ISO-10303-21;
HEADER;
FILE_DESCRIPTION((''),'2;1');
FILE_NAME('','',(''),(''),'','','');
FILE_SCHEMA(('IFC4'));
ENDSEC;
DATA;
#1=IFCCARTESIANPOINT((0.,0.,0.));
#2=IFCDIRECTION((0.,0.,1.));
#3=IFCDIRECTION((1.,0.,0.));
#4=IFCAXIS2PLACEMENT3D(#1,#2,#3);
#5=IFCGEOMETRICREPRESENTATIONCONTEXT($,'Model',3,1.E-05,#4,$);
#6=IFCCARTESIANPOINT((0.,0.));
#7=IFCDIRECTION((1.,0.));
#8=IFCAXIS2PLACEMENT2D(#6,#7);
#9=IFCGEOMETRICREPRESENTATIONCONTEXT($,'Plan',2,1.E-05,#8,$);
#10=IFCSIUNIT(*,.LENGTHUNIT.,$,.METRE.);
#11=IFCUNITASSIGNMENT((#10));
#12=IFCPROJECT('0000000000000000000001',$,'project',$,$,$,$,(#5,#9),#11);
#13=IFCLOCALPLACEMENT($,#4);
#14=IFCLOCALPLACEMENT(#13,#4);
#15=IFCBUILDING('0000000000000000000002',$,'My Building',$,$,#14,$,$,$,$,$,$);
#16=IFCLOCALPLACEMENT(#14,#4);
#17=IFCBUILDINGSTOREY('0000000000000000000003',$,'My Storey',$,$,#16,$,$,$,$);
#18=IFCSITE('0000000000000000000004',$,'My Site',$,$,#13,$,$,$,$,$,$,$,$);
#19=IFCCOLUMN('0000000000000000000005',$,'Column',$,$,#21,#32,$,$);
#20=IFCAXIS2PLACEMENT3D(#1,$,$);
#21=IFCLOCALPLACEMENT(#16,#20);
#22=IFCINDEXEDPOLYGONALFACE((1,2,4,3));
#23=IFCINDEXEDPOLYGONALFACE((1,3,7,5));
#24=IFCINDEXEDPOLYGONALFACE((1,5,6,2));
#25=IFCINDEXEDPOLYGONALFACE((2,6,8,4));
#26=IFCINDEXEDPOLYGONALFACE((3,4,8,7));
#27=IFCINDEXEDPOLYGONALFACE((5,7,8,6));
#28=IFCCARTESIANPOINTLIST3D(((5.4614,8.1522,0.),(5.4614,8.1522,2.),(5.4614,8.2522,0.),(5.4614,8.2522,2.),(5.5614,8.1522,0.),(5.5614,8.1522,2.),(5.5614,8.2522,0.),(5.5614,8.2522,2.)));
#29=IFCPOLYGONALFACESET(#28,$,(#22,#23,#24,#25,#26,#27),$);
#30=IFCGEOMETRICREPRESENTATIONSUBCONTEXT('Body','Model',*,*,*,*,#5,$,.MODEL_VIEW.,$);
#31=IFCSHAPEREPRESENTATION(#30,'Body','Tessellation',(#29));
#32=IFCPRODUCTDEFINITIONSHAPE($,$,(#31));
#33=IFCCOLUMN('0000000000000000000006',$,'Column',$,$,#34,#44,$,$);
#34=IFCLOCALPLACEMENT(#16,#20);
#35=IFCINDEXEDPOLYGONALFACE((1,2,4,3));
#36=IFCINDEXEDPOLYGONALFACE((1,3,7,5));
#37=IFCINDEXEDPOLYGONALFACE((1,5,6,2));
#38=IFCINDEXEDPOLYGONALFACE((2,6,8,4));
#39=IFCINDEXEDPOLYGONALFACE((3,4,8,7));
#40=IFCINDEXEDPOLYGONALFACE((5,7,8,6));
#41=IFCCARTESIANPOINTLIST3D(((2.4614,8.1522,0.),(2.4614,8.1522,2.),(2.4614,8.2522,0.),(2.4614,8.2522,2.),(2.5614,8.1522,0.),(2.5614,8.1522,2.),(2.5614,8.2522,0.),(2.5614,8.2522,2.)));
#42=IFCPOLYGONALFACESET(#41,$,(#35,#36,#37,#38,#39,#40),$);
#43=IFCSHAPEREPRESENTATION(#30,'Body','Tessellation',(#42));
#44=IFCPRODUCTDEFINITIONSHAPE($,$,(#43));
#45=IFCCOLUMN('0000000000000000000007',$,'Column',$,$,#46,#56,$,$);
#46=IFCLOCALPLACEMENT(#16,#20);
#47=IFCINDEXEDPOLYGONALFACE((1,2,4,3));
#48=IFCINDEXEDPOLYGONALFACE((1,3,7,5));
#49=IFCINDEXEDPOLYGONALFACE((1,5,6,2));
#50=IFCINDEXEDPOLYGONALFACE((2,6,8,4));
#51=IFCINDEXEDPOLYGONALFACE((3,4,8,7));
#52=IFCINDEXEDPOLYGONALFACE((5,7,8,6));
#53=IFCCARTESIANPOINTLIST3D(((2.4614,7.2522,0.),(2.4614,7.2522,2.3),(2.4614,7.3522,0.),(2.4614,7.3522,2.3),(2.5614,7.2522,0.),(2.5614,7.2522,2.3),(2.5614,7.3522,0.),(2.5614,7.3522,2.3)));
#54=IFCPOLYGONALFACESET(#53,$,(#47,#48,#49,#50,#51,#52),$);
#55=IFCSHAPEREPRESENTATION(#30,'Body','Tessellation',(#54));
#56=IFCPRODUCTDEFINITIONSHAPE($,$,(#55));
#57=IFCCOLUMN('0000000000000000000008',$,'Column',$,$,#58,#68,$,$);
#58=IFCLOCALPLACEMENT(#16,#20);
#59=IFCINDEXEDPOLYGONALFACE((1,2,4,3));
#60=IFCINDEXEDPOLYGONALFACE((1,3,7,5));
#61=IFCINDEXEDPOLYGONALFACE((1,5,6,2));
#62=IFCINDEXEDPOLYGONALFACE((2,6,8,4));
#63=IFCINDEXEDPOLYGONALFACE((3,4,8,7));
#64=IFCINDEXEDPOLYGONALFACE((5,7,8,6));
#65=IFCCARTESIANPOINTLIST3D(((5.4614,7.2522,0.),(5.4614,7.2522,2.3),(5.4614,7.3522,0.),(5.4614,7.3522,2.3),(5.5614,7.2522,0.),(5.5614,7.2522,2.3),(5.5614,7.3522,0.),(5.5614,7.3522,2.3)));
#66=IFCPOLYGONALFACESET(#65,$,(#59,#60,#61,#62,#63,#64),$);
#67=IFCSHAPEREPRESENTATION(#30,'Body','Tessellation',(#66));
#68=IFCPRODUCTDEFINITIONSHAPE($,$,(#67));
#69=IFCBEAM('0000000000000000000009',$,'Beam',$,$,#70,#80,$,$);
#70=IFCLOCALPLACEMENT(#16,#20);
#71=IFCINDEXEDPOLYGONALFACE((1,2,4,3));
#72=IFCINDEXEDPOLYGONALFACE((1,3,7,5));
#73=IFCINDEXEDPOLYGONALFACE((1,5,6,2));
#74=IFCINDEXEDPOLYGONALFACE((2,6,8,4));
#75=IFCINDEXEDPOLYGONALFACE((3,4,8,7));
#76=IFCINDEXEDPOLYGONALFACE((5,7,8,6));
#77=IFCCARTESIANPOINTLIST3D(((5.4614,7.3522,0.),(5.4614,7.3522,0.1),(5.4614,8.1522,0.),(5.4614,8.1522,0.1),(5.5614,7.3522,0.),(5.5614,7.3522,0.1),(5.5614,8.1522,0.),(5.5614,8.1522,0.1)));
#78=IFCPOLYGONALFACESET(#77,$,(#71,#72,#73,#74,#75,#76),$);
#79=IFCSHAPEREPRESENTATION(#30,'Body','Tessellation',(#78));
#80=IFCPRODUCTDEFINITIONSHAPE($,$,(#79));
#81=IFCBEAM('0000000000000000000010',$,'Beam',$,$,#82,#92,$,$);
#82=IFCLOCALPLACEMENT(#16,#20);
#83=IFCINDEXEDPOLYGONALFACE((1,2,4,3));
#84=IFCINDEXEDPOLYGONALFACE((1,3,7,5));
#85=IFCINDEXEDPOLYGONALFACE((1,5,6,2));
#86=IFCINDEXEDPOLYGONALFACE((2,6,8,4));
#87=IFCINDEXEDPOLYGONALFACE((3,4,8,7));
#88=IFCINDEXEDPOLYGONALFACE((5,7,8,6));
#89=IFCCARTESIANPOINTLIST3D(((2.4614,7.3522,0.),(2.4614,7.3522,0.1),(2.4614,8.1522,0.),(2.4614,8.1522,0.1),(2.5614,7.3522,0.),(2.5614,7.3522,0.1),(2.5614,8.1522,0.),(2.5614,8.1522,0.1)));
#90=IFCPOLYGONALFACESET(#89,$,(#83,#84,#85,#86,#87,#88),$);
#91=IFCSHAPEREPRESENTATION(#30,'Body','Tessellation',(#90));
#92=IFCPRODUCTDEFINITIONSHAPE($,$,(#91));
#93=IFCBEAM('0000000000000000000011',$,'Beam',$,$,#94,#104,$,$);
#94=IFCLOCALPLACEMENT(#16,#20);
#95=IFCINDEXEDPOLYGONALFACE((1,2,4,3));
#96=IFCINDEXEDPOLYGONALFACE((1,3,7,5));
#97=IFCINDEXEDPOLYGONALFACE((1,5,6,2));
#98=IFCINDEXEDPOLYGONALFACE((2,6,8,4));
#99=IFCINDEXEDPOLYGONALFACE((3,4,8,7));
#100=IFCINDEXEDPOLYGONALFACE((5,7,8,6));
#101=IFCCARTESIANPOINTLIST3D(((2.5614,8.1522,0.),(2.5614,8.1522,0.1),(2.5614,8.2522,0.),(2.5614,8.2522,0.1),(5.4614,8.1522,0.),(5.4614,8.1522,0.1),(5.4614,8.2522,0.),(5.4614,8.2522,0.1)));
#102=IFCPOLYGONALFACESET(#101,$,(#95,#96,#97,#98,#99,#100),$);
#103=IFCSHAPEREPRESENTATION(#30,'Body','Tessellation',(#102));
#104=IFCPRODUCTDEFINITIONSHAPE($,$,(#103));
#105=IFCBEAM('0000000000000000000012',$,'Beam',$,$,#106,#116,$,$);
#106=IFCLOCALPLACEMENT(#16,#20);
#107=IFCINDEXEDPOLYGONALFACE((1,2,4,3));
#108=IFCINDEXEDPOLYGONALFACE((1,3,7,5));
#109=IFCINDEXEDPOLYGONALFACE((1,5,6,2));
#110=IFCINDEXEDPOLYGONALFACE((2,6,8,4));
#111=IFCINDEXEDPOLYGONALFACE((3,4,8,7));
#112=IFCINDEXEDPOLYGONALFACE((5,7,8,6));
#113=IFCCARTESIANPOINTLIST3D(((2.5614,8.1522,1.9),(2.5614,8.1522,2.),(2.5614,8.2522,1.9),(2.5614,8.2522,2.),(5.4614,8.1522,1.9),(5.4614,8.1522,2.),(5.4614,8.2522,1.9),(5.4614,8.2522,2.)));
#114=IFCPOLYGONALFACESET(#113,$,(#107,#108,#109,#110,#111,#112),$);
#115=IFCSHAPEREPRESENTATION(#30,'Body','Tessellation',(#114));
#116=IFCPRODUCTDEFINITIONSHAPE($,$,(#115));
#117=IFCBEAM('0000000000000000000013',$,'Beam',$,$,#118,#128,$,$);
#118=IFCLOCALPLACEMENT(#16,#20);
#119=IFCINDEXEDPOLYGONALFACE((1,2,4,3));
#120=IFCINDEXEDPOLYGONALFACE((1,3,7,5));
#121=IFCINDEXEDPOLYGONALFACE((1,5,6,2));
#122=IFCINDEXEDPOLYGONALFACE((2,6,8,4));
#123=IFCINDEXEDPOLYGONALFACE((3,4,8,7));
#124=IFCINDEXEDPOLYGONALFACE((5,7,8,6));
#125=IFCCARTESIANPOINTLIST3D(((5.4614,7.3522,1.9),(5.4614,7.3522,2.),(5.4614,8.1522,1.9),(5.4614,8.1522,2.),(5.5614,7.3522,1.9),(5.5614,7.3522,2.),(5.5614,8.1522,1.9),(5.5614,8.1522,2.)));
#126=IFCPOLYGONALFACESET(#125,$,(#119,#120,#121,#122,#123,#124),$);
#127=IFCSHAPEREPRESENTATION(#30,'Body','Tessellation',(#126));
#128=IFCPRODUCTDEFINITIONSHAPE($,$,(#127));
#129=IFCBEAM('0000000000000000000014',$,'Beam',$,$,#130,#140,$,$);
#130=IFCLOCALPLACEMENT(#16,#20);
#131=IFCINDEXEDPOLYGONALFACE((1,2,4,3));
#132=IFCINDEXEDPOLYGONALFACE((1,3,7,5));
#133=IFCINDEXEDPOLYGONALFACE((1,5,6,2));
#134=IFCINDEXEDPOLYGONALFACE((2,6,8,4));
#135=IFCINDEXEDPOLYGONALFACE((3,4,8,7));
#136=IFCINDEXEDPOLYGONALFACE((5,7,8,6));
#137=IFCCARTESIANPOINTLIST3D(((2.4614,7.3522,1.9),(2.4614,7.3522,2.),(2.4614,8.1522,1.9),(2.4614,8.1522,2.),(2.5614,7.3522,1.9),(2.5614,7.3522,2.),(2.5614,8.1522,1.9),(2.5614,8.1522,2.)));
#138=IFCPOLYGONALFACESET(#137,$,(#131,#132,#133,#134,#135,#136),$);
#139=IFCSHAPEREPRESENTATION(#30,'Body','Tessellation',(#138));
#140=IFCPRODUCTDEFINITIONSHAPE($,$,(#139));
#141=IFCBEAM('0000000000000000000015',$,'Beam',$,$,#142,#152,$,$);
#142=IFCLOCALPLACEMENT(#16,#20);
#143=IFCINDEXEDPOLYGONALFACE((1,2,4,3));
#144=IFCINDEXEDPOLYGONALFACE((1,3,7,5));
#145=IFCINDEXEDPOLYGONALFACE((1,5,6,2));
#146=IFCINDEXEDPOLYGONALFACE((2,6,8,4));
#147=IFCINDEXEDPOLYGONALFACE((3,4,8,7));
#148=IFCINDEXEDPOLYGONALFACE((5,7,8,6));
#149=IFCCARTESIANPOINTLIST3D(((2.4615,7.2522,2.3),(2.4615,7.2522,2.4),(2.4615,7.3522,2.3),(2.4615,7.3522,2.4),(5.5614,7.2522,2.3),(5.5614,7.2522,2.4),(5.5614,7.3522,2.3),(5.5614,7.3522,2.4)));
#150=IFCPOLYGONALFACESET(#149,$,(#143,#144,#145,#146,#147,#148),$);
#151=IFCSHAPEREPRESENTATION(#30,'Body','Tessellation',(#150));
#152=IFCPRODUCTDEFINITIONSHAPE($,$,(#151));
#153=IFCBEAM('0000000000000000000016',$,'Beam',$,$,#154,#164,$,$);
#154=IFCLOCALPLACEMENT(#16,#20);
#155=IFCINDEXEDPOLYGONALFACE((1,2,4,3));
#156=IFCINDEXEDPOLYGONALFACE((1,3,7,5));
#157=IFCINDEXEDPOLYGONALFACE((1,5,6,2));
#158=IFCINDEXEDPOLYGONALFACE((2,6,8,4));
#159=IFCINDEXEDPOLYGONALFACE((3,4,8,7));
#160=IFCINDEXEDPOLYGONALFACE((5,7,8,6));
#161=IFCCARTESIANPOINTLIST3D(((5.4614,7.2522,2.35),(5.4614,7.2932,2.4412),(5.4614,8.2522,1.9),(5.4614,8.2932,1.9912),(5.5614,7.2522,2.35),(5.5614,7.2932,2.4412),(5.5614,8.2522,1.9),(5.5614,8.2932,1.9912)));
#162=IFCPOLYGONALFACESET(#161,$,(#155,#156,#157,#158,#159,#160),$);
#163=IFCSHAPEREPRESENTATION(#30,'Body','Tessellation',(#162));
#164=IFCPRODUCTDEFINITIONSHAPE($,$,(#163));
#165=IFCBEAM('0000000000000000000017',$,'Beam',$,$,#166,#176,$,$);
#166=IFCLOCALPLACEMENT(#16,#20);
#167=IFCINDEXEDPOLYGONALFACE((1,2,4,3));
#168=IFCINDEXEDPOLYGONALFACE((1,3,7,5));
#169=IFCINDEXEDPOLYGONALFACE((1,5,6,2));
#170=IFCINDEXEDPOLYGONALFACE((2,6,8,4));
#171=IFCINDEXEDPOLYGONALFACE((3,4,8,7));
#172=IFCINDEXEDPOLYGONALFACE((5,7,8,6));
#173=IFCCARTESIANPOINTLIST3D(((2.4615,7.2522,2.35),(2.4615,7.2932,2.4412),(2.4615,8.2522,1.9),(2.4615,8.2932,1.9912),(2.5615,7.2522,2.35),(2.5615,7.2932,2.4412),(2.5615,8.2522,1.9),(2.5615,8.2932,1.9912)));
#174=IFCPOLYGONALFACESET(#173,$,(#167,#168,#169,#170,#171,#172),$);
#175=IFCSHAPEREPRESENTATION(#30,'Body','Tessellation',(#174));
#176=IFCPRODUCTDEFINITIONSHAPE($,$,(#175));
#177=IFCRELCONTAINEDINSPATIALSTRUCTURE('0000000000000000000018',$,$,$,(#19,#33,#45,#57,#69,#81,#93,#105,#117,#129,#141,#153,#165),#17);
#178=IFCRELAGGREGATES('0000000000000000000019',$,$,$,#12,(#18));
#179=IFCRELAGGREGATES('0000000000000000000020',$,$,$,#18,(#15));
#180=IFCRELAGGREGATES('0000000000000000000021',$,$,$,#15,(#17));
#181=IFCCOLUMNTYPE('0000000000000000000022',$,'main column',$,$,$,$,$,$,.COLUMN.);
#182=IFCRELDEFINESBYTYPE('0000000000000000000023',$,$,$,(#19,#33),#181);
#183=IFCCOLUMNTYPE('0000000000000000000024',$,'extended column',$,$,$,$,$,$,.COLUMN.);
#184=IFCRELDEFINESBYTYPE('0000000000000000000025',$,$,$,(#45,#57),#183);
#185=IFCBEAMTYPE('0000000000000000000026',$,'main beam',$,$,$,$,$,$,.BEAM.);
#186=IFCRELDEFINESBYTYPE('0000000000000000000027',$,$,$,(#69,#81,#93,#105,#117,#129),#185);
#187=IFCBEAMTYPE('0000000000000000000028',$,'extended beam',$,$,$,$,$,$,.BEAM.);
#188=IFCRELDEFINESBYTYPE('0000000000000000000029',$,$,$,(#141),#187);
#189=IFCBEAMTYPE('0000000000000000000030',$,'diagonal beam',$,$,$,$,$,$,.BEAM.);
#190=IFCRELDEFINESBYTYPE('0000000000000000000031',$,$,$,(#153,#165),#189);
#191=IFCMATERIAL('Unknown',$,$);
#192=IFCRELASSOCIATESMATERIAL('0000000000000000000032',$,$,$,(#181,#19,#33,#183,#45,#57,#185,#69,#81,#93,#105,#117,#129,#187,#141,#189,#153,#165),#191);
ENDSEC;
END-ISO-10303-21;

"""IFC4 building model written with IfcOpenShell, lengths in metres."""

from ifc_helpers import new_model, si_unit, frame, origin_with_axes, origin_2d_with_axis, place, context, subcontext, project, spatial, rectangle, extrude, material, material_profile, profile_set, profile_usage, type_object, element, save


model = new_model("IFC4")

# Units and contexts
model_context = context("Model", 3, precision=1e-05, world=origin_with_axes())
plan_context = context("Plan", 2, precision=1e-05, world=origin_2d_with_axis())
body_context = subcontext(model_context, "Body", "Model", "MODEL_VIEW")
ifc_project = project(units=[si_unit("LENGTHUNIT", "METRE")], contexts=[model_context, plan_context])

# Site, building, storey
site_placement = place(None, origin_with_axes())
site = spatial("IfcSite", under=ifc_project, at=site_placement, Name="My Site")
building_placement = place(site_placement, origin_with_axes())
building = spatial("IfcBuilding", under=site, at=building_placement, Name="My Building")
storey_placement = place(building_placement, origin_with_axes())
storey = spatial("IfcBuildingStorey", under=building, at=storey_placement, Name="My Storey")

# Columns
ifc_material_1 = material(Name="Unknown")
ifc_material_profile_1 = material_profile(ifc_material_1, rectangle(XDim=0.1, YDim=0.1))
ifc_profile_set_1 = profile_set([ifc_material_profile_1])
ifc_profile_usage_1 = profile_usage(ifc_profile_set_1, cardinal=5)
column_type_1 = type_object("IfcColumnType", Name="main column", PredefinedType="COLUMN", material=ifc_profile_set_1)
column_1_placement = place(storey_placement, frame((5.5114, 8.2022, 0.0), z_axis=(0.0, 0.0, 1.0), x_axis=(0.0, 1.0, 0.0)))
element("IfcColumn", 1, at=column_1_placement, inside=storey, type_object=column_type_1, material=ifc_profile_usage_1, Name="Column", context=body_context, shape_type="SweptSolid", body=[
    extrude(rectangle(XDim=0.1, YDim=0.1), origin_with_axes(), (0.0, 0.0, 1.0), 2.0),
])
ifc_profile_usage_2 = profile_usage(ifc_profile_set_1, cardinal=5)
column_2_placement = place(storey_placement, frame((2.5114, 8.2022, 0.0), z_axis=(0.0, 0.0, 1.0), x_axis=(0.0, 1.0, 0.0)))
element("IfcColumn", 2, at=column_2_placement, inside=storey, type_object=column_type_1, material=ifc_profile_usage_2, Name="Column", context=body_context, shape_type="SweptSolid", body=[
    extrude(rectangle(XDim=0.1, YDim=0.1), origin_with_axes(), (0.0, 0.0, 1.0), 2.0),
])
ifc_material_profile_2 = material_profile(ifc_material_1, rectangle(XDim=0.1, YDim=0.1))
ifc_profile_set_2 = profile_set([ifc_material_profile_2])
ifc_profile_usage_3 = profile_usage(ifc_profile_set_2, cardinal=5)
column_type_2 = type_object("IfcColumnType", Name="extended column", PredefinedType="COLUMN", material=ifc_profile_set_2)
column_3_placement = place(storey_placement, frame((2.5114, 7.3022, 0.0), z_axis=(0.0, 0.0, 1.0), x_axis=(0.0, 1.0, 0.0)))
element("IfcColumn", 3, at=column_3_placement, inside=storey, type_object=column_type_2, material=ifc_profile_usage_3, Name="Column", context=body_context, shape_type="SweptSolid", body=[
    extrude(rectangle(XDim=0.1, YDim=0.1), origin_with_axes(), (0.0, 0.0, 1.0), 2.3),
])
ifc_profile_usage_4 = profile_usage(ifc_profile_set_2, cardinal=5)
column_4_placement = place(storey_placement, frame((5.5114, 7.3022, 0.0), z_axis=(0.0, 0.0, 1.0), x_axis=(0.0, 1.0, 0.0)))
element("IfcColumn", 4, at=column_4_placement, inside=storey, type_object=column_type_2, material=ifc_profile_usage_4, Name="Column", context=body_context, shape_type="SweptSolid", body=[
    extrude(rectangle(XDim=0.1, YDim=0.1), origin_with_axes(), (0.0, 0.0, 1.0), 2.3),
])

# Beams
ifc_material_profile_3 = material_profile(ifc_material_1, rectangle(XDim=0.1, YDim=0.1))
ifc_profile_set_3 = profile_set([ifc_material_profile_3])
ifc_profile_usage_5 = profile_usage(ifc_profile_set_3, cardinal=5)
beam_type_1 = type_object("IfcBeamType", Name="main beam", PredefinedType="BEAM", material=ifc_profile_set_3)
beam_1_placement = place(storey_placement, frame((5.5114, 7.3522, 0.05), z_axis=(0.0, 1.0, 0.0), x_axis=(-1.0, 0.0, 0.0)))
element("IfcBeam", 5, at=beam_1_placement, inside=storey, type_object=beam_type_1, material=ifc_profile_usage_5, Name="Beam", context=body_context, shape_type="SweptSolid", body=[
    extrude(rectangle(XDim=0.1, YDim=0.1), origin_with_axes(), (0.0, 0.0, 1.0), 0.8),
])
ifc_profile_usage_6 = profile_usage(ifc_profile_set_3, cardinal=5)
beam_2_placement = place(storey_placement, frame((2.5114, 7.3522, 0.05), z_axis=(0.0, 1.0, 0.0), x_axis=(-1.0, 0.0, 0.0)))
element("IfcBeam", 6, at=beam_2_placement, inside=storey, type_object=beam_type_1, material=ifc_profile_usage_6, Name="Beam", context=body_context, shape_type="SweptSolid", body=[
    extrude(rectangle(XDim=0.1, YDim=0.1), origin_with_axes(), (0.0, 0.0, 1.0), 0.8),
])
ifc_profile_usage_7 = profile_usage(ifc_profile_set_3, cardinal=5)
beam_3_placement = place(storey_placement, frame((2.5614, 8.2022, 0.05), z_axis=(1.0, 0.0, 0.0), x_axis=(0.0, 1.0, 0.0)))
element("IfcBeam", 7, at=beam_3_placement, inside=storey, type_object=beam_type_1, material=ifc_profile_usage_7, Name="Beam", context=body_context, shape_type="SweptSolid", body=[
    extrude(rectangle(XDim=0.1, YDim=0.1), origin_with_axes(), (0.0, 0.0, 1.0), 2.9),
])
ifc_profile_usage_8 = profile_usage(ifc_profile_set_3, cardinal=5)
beam_4_placement = place(storey_placement, frame((2.5614, 8.2022, 1.95), z_axis=(1.0, 0.0, 0.0), x_axis=(0.0, 1.0, 0.0)))
element("IfcBeam", 8, at=beam_4_placement, inside=storey, type_object=beam_type_1, material=ifc_profile_usage_8, Name="Beam", context=body_context, shape_type="SweptSolid", body=[
    extrude(rectangle(XDim=0.1, YDim=0.1), origin_with_axes(), (0.0, 0.0, 1.0), 2.9),
])
ifc_profile_usage_9 = profile_usage(ifc_profile_set_3, cardinal=5)
beam_5_placement = place(storey_placement, frame((5.5114, 7.3522, 1.95), z_axis=(0.0, 1.0, 0.0), x_axis=(-1.0, 0.0, 0.0)))
element("IfcBeam", 9, at=beam_5_placement, inside=storey, type_object=beam_type_1, material=ifc_profile_usage_9, Name="Beam", context=body_context, shape_type="SweptSolid", body=[
    extrude(rectangle(XDim=0.1, YDim=0.1), origin_with_axes(), (0.0, 0.0, 1.0), 0.8),
])
ifc_profile_usage_10 = profile_usage(ifc_profile_set_3, cardinal=5)
beam_6_placement = place(storey_placement, frame((2.5114, 7.3522, 1.95), z_axis=(0.0, 1.0, 0.0), x_axis=(-1.0, 0.0, 0.0)))
element("IfcBeam", 10, at=beam_6_placement, inside=storey, type_object=beam_type_1, material=ifc_profile_usage_10, Name="Beam", context=body_context, shape_type="SweptSolid", body=[
    extrude(rectangle(XDim=0.1, YDim=0.1), origin_with_axes(), (0.0, 0.0, 1.0), 0.8),
])
ifc_material_profile_4 = material_profile(ifc_material_1, rectangle(XDim=0.1, YDim=0.1))
ifc_profile_set_4 = profile_set([ifc_material_profile_4])
ifc_profile_usage_11 = profile_usage(ifc_profile_set_4, cardinal=5)
beam_type_2 = type_object("IfcBeamType", Name="extended beam", PredefinedType="BEAM", material=ifc_profile_set_4)
beam_7_placement = place(storey_placement, frame((2.4615, 7.3022, 2.35), z_axis=(1.0, 0.0, 0.0), x_axis=(0.0, 1.0, 0.0)))
element("IfcBeam", 11, at=beam_7_placement, inside=storey, type_object=beam_type_2, material=ifc_profile_usage_11, Name="Beam", context=body_context, shape_type="SweptSolid", body=[
    extrude(rectangle(XDim=0.1, YDim=0.1), origin_with_axes(), (0.0, 0.0, 1.0), 3.0999),
])
ifc_material_profile_5 = material_profile(ifc_material_1, rectangle(XDim=0.1, YDim=0.1))
ifc_profile_set_5 = profile_set([ifc_material_profile_5])
ifc_profile_usage_12 = profile_usage(ifc_profile_set_5, cardinal=5)
beam_type_3 = type_object("IfcBeamType", Name="diagonal beam", PredefinedType="BEAM", material=ifc_profile_set_5)
beam_8_placement = place(storey_placement, frame((5.5114, 7.2727, 2.3956), z_axis=(0.0, 0.911922, -0.410365), x_axis=(-1.0, 0.0, 0.0)))
element("IfcBeam", 12, at=beam_8_placement, inside=storey, type_object=beam_type_3, material=ifc_profile_usage_12, Name="Beam", context=body_context, shape_type="SweptSolid", body=[
    extrude(rectangle(XDim=0.1, YDim=0.1), origin_with_axes(), (0.0, 0.0, 1.0), 1.0966),
])
ifc_profile_usage_13 = profile_usage(ifc_profile_set_5, cardinal=5)
beam_9_placement = place(storey_placement, frame((2.5115, 7.2727, 2.3956), z_axis=(0.0, 0.911922, -0.410365), x_axis=(-1.0, 0.0, 0.0)))
element("IfcBeam", 13, at=beam_9_placement, inside=storey, type_object=beam_type_3, material=ifc_profile_usage_13, Name="Beam", context=body_context, shape_type="SweptSolid", body=[
    extrude(rectangle(XDim=0.1, YDim=0.1), origin_with_axes(), (0.0, 0.0, 1.0), 1.0966),
])

save(model, "model.ifc")
